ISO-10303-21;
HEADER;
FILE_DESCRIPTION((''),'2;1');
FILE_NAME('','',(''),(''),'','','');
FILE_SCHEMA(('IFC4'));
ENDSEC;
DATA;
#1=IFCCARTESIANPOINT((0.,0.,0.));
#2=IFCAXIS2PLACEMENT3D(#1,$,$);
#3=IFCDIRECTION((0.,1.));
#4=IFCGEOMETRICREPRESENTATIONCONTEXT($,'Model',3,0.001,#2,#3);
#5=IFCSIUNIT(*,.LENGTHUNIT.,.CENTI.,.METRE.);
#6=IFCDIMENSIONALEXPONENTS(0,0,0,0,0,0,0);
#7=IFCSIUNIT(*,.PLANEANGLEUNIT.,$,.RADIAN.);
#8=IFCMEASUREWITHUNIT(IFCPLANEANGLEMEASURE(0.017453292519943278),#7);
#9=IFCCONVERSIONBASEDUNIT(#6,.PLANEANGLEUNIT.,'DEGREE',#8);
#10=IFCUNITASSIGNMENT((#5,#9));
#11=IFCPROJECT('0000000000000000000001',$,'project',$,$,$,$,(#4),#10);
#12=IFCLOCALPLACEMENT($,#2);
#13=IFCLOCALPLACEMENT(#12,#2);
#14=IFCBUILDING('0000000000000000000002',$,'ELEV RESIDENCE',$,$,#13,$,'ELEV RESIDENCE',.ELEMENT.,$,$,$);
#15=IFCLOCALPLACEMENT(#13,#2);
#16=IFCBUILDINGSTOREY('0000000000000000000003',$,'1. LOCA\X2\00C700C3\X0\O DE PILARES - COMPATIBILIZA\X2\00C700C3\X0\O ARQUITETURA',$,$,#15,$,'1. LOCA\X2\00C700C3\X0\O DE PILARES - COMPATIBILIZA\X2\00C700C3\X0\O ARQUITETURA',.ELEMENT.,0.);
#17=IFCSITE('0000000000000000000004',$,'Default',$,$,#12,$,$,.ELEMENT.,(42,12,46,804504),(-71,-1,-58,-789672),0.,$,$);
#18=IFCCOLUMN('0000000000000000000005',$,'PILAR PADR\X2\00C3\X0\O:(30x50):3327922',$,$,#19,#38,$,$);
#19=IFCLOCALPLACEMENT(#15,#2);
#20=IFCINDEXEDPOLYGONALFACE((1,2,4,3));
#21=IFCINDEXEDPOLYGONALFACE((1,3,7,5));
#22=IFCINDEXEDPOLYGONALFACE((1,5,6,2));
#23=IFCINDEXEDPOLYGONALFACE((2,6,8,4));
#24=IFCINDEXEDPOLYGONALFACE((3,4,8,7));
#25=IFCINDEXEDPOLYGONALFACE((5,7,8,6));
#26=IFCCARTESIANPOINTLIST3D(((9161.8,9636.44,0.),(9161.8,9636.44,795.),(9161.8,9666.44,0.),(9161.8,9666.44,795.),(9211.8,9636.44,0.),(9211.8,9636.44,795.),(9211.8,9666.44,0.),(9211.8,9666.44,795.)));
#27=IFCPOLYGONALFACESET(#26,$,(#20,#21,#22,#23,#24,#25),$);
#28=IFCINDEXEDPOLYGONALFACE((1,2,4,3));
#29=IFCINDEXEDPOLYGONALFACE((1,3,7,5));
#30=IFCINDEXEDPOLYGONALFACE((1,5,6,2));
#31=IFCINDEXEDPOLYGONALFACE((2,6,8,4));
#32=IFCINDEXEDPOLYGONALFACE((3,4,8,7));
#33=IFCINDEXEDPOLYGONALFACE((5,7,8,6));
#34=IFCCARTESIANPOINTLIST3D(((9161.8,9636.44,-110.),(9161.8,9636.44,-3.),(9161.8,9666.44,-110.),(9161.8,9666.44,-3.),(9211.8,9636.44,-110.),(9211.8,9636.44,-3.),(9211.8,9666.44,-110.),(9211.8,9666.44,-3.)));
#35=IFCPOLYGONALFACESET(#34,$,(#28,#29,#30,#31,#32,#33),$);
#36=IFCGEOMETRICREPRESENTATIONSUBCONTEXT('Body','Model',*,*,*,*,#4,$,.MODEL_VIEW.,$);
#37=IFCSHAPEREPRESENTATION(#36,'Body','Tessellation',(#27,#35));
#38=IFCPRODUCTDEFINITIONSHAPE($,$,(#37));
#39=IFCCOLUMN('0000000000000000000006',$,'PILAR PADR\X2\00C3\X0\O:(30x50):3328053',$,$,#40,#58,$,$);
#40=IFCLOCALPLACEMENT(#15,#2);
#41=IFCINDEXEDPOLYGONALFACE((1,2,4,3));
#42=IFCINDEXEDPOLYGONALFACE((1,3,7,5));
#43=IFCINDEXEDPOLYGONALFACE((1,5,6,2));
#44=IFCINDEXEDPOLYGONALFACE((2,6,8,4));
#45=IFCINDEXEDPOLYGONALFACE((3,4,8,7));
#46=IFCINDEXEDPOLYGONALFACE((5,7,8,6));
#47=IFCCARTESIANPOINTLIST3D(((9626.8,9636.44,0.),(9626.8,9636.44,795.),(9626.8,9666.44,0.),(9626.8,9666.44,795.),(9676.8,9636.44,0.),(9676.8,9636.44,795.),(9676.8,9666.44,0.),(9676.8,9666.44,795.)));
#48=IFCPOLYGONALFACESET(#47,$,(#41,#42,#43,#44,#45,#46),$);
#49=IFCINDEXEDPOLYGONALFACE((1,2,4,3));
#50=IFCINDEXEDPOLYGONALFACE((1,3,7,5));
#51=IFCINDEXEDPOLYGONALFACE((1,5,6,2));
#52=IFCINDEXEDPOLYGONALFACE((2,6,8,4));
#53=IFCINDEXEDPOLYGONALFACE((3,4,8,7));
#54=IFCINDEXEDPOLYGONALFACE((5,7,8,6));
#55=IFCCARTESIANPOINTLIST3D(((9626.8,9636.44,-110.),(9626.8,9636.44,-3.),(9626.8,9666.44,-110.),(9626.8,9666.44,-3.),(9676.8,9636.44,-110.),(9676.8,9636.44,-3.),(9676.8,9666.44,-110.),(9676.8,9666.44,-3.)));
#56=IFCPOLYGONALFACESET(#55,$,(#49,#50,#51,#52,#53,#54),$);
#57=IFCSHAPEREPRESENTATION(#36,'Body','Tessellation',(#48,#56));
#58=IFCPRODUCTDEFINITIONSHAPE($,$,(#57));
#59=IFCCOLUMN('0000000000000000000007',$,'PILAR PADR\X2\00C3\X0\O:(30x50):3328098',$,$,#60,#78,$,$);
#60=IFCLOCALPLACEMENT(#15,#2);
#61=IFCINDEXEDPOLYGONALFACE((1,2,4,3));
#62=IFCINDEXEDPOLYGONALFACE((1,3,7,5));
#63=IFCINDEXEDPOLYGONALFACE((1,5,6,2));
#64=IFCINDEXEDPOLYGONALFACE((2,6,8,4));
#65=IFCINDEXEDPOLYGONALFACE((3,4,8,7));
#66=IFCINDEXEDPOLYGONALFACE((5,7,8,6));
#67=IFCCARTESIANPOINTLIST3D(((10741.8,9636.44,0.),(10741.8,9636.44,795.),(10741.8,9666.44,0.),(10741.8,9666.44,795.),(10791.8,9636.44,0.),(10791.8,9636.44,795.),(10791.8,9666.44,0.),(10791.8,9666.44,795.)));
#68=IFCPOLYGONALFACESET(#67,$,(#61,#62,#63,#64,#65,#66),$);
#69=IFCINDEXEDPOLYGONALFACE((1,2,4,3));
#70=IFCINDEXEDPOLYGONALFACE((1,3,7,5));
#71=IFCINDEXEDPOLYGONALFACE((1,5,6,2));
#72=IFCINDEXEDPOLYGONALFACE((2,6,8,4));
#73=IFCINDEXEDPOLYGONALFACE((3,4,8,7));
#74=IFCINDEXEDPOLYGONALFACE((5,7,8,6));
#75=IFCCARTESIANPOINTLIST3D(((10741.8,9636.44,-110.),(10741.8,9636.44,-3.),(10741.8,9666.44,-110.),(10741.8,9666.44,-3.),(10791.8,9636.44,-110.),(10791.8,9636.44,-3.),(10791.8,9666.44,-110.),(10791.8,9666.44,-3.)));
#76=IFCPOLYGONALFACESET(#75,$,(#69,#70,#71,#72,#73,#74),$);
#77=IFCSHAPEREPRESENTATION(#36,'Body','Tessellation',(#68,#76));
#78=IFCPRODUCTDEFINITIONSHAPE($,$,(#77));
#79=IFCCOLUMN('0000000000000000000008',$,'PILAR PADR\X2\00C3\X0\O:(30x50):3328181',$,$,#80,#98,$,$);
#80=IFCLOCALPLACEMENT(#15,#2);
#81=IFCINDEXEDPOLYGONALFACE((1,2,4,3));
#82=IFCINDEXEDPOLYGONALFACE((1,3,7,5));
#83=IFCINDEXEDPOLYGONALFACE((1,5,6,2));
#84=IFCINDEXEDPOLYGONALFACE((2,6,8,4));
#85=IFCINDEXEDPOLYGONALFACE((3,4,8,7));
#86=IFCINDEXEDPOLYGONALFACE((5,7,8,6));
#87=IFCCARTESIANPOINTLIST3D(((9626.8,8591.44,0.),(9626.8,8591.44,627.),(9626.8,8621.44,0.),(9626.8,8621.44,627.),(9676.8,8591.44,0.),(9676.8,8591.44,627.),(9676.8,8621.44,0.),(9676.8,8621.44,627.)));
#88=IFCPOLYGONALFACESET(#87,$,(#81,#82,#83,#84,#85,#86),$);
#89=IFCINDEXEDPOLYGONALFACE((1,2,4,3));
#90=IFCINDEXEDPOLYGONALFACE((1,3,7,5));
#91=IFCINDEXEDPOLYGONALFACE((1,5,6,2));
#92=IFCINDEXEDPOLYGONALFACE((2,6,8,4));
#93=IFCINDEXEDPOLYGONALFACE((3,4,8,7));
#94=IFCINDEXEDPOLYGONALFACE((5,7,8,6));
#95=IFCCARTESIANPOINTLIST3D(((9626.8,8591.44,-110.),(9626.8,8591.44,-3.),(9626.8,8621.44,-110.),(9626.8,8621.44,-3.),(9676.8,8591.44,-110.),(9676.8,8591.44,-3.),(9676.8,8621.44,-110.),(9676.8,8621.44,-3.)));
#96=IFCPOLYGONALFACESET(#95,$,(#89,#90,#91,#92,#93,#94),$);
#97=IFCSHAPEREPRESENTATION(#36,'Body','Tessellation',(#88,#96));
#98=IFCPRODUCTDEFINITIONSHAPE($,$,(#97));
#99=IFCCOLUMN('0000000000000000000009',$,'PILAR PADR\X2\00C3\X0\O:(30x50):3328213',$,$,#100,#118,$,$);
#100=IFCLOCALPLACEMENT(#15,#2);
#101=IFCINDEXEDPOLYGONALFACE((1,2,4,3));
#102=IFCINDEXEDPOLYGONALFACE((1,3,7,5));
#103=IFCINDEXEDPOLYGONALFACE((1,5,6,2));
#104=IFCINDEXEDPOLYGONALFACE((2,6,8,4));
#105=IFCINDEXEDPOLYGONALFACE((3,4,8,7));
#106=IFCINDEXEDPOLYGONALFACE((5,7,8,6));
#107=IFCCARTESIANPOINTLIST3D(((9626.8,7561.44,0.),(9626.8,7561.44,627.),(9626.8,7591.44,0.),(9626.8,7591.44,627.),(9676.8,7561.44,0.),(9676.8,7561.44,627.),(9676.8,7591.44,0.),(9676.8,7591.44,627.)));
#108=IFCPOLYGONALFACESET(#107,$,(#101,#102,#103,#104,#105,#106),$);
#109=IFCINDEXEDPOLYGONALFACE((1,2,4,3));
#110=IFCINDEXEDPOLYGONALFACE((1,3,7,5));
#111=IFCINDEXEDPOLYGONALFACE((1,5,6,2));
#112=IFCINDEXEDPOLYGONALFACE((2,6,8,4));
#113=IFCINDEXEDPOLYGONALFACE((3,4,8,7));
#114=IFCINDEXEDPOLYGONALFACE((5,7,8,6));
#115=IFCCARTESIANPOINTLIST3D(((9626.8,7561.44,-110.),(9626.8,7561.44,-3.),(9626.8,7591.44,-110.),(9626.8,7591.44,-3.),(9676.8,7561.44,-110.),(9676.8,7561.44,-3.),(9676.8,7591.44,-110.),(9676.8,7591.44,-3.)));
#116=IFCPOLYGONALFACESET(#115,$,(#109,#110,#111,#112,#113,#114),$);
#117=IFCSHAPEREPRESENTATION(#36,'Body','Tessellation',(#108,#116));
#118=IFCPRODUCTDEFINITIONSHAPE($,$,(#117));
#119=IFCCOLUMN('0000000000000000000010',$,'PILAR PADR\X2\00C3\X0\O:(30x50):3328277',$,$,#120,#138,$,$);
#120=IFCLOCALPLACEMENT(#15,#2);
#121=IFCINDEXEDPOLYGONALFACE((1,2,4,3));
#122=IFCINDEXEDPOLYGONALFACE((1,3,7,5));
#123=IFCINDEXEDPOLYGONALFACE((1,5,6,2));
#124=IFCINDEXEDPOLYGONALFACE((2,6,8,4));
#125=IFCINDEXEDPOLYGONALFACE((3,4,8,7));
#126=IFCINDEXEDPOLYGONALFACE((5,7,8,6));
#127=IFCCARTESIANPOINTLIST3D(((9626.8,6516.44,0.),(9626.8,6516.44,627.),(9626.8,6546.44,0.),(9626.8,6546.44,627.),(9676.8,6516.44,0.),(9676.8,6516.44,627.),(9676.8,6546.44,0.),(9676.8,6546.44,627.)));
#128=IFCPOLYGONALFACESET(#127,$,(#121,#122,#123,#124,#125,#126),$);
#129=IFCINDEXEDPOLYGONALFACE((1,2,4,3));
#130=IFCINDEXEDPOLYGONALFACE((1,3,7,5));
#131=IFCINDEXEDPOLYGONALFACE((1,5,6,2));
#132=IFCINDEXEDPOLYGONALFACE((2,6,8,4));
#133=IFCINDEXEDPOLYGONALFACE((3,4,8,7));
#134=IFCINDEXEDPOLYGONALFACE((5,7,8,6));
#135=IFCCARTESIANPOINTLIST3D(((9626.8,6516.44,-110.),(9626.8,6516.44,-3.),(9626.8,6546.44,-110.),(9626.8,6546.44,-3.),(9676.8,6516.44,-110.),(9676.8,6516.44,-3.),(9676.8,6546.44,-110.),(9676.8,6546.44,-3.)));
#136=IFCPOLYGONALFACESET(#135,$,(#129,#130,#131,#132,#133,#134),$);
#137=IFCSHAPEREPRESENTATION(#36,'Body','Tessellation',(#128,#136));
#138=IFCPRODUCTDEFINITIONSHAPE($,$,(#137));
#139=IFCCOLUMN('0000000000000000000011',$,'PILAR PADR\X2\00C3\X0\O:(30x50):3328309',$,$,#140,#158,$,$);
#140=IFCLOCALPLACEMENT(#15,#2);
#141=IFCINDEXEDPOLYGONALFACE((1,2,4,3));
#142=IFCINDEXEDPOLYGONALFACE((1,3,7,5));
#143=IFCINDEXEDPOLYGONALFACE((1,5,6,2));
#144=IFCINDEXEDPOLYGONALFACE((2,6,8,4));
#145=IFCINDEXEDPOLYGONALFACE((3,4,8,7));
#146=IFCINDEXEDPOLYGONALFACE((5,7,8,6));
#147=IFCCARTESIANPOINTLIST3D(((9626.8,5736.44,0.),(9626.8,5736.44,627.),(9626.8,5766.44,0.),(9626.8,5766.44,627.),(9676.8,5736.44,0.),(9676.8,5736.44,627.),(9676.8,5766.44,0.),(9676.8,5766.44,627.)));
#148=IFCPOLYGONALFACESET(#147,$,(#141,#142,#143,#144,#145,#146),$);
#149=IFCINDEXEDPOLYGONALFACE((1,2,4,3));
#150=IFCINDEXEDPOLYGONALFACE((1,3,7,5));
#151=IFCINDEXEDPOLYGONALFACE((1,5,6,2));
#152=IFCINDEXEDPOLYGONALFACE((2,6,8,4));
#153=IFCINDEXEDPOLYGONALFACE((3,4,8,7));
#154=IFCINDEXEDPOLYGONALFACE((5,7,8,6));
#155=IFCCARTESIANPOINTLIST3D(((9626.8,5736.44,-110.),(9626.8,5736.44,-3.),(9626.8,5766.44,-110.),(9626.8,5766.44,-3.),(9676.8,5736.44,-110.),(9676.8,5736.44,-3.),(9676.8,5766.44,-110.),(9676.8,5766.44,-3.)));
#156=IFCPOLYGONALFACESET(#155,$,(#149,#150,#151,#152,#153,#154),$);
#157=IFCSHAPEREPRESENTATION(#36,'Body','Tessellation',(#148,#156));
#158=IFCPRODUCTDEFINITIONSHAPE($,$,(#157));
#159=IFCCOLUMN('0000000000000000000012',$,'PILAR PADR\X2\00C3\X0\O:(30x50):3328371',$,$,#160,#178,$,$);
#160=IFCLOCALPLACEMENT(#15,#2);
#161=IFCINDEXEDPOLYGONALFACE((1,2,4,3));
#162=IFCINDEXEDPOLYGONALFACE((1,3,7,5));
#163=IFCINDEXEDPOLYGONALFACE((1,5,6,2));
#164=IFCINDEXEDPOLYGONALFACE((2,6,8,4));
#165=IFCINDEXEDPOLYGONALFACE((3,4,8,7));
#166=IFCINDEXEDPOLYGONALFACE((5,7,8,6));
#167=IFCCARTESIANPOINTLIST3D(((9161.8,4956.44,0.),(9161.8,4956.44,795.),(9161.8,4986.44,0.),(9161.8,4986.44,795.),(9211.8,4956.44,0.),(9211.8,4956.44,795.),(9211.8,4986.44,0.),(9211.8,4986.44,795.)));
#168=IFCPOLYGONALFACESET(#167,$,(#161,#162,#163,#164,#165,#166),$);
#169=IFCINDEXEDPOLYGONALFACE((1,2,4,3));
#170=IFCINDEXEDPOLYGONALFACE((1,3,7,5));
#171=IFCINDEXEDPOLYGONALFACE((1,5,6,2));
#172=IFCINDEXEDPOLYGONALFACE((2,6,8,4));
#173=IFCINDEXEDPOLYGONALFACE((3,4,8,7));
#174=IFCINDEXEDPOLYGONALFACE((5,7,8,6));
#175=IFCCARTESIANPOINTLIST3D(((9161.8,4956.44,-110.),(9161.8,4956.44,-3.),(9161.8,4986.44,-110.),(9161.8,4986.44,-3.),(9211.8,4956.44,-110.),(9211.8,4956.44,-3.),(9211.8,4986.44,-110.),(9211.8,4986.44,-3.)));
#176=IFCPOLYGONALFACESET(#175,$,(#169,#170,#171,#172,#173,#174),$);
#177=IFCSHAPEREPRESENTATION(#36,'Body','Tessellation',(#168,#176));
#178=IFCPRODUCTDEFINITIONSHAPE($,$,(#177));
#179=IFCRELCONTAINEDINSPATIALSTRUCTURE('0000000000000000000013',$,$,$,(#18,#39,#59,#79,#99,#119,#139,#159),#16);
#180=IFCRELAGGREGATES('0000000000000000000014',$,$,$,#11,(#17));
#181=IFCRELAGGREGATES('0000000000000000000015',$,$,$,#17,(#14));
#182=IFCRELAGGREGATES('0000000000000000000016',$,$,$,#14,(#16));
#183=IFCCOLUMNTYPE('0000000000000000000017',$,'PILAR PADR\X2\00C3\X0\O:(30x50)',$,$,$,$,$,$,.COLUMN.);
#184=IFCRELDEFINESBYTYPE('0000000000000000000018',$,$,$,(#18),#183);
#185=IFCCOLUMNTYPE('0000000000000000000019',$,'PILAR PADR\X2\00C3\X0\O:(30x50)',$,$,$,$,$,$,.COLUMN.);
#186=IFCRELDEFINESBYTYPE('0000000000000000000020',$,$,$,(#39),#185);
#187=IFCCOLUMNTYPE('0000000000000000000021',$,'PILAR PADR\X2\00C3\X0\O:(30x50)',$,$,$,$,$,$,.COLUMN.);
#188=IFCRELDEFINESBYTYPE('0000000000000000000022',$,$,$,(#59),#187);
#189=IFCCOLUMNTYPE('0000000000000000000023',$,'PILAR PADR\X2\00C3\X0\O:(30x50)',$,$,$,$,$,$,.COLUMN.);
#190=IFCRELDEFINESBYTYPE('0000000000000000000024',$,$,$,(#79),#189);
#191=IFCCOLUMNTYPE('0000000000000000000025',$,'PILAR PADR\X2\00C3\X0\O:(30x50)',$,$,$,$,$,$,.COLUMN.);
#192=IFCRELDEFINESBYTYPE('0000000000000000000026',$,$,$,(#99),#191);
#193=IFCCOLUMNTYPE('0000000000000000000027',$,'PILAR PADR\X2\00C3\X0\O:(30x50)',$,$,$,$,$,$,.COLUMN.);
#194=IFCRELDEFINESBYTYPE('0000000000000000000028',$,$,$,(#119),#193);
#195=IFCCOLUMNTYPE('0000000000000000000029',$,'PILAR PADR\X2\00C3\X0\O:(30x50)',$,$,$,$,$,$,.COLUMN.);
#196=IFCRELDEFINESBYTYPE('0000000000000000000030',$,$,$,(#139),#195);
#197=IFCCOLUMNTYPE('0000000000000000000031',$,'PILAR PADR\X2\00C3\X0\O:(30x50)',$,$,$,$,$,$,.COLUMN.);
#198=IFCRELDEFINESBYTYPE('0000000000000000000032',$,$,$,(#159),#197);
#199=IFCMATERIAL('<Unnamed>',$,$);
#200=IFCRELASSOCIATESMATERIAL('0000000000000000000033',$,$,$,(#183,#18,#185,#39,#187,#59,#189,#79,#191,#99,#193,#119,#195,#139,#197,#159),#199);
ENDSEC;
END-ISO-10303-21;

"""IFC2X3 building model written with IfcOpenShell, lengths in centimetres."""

from ifc_helpers import new_model, entity, si_unit, converted_unit, direction, frame, frame_2d, origin, origin_2d_with_axis, place, context, subcontext, project, spatial, rectangle, extrude, source, transform, mapped, material, type_object, type_shapes, element, save


model = new_model("IFC2X3")

# Units and contexts
model_context = context("Model", 3, precision=0.001, world=origin(), true_north=direction((0.0, 1.0)))
body_context = subcontext(model_context, "Body", "Model", "MODEL_VIEW")
ifc_project = project(units=[si_unit("LENGTHUNIT", "METRE", prefix="CENTI"), converted_unit("PLANEANGLEUNIT", "DEGREE", entity("IfcPlaneAngleMeasure", 0.017453292519943278), si_unit("PLANEANGLEUNIT", "RADIAN"), dimensions=[0, 0, 0, 0, 0, 0, 0])], contexts=[model_context])

# Site, building, storey
site_placement = place(None, origin())
site = spatial("IfcSite", under=ifc_project, at=site_placement, Name="Default", CompositionType="ELEMENT", RefLatitude=(42, 12, 46, 804504), RefLongitude=(-71, -1, -58, -789672), RefElevation=0.0)
building_placement = place(site_placement, origin())
building = spatial("IfcBuilding", under=site, at=building_placement, Name="ELEV RESIDENCE", LongName="ELEV RESIDENCE", CompositionType="ELEMENT")
storey_placement = place(building_placement, origin())
storey = spatial("IfcBuildingStorey", under=building, at=storey_placement, Name="1. LOCAÇÃO DE PILARES - COMPATIBILIZAÇÃO ARQUITETURA", LongName="1. LOCAÇÃO DE PILARES - COMPATIBILIZAÇÃO ARQUITETURA", CompositionType="ELEMENT", Elevation=0.0)

# Columns
ifc_material_1 = material(Name="<Unnamed>")
column_type_1 = type_object("IfcColumnType", Name="PILAR PADRÃO:(30x50)", PredefinedType="COLUMN", material=ifc_material_1)
shared_shape_1 = source(origin(), body_context, "Body", "SweptSolid", [
    extrude(rectangle(XDim=795.0, YDim=30.0, at=origin_2d_with_axis()), frame((9161.8, 9651.44, 397.5), z_axis=(1.0, 0.0, 0.0), x_axis=(0.0, 0.0, -1.0)), (0.0, 0.0, 1.0), 50.0),
    extrude(rectangle(XDim=107.0, YDim=30.0, at=frame_2d((0.0, 0.0), x_axis=(1.0, 0.0))), frame((9161.8, 9651.44, -56.5), z_axis=(1.0, 0.0, 0.0), x_axis=(0.0, 0.0, 1.0)), (0.0, 0.0, 1.0), 50.0),
])
type_shapes(column_type_1, [shared_shape_1])
column_1_placement = place(storey_placement, origin())
element("IfcColumn", 1, at=column_1_placement, inside=storey, type_object=column_type_1, material=ifc_material_1, Name="PILAR PADRÃO:(30x50):3327922", context=body_context, shape_type="MappedRepresentation", body=[
    mapped(shared_shape_1, transform((0.0, 0.0, 0.0), scale=1.0)),
])
column_type_2 = type_object("IfcColumnType", Name="PILAR PADRÃO:(30x50)", PredefinedType="COLUMN", material=ifc_material_1)
shared_shape_2 = source(origin(), body_context, "Body", "SweptSolid", [
    extrude(rectangle(XDim=795.0, YDim=30.0, at=frame_2d((-86.75, 0.0), x_axis=(1.0, 0.0))), frame((9626.8, 9651.44, 310.75), z_axis=(1.0, 0.0, 0.0), x_axis=(0.0, 0.0, -1.0)), (0.0, 0.0, 1.0), 50.0),
    extrude(rectangle(XDim=107.0, YDim=30.0, at=frame_2d((0.0, 0.0), x_axis=(1.0, 0.0))), frame((9626.8, 9651.44, -56.5), z_axis=(1.0, 0.0, 0.0), x_axis=(0.0, 0.0, 1.0)), (0.0, 0.0, 1.0), 50.0),
])
type_shapes(column_type_2, [shared_shape_2])
column_2_placement = place(storey_placement, origin())
element("IfcColumn", 2, at=column_2_placement, inside=storey, type_object=column_type_2, material=ifc_material_1, Name="PILAR PADRÃO:(30x50):3328053", context=body_context, shape_type="MappedRepresentation", body=[
    mapped(shared_shape_2, transform((0.0, 0.0, 0.0), scale=1.0)),
])
column_type_3 = type_object("IfcColumnType", Name="PILAR PADRÃO:(30x50)", PredefinedType="COLUMN", material=ifc_material_1)
shared_shape_3 = source(origin(), body_context, "Body", "SweptSolid", [
    extrude(rectangle(XDim=795.0, YDim=30.0, at=frame_2d((-86.75, 0.0), x_axis=(1.0, 0.0))), frame((10741.8, 9651.44, 310.75), z_axis=(1.0, 0.0, 0.0), x_axis=(0.0, 0.0, -1.0)), (0.0, 0.0, 1.0), 50.0),
    extrude(rectangle(XDim=107.0, YDim=30.0, at=frame_2d((0.0, 0.0), x_axis=(1.0, 0.0))), frame((10741.8, 9651.44, -56.5), z_axis=(1.0, 0.0, 0.0), x_axis=(0.0, 0.0, 1.0)), (0.0, 0.0, 1.0), 50.0),
])
type_shapes(column_type_3, [shared_shape_3])
column_3_placement = place(storey_placement, origin())
element("IfcColumn", 3, at=column_3_placement, inside=storey, type_object=column_type_3, material=ifc_material_1, Name="PILAR PADRÃO:(30x50):3328098", context=body_context, shape_type="MappedRepresentation", body=[
    mapped(shared_shape_3, transform((0.0, 0.0, 0.0), scale=1.0)),
])
column_type_4 = type_object("IfcColumnType", Name="PILAR PADRÃO:(30x50)", PredefinedType="COLUMN", material=ifc_material_1)
shared_shape_4 = source(origin(), body_context, "Body", "SweptSolid", [
    extrude(rectangle(XDim=627.0, YDim=30.0, at=origin_2d_with_axis()), frame((9626.8, 8606.44, 313.5), z_axis=(1.0, 0.0, 0.0), x_axis=(0.0, 0.0, -1.0)), (0.0, 0.0, 1.0), 50.0),
    extrude(rectangle(XDim=107.0, YDim=30.0, at=frame_2d((0.0, 0.0), x_axis=(1.0, 0.0))), frame((9626.8, 8606.44, -56.5), z_axis=(1.0, 0.0, 0.0), x_axis=(0.0, 0.0, 1.0)), (0.0, 0.0, 1.0), 50.0),
])
type_shapes(column_type_4, [shared_shape_4])
column_4_placement = place(storey_placement, origin())
element("IfcColumn", 4, at=column_4_placement, inside=storey, type_object=column_type_4, material=ifc_material_1, Name="PILAR PADRÃO:(30x50):3328181", context=body_context, shape_type="MappedRepresentation", body=[
    mapped(shared_shape_4, transform((0.0, 0.0, 0.0), scale=1.0)),
])
column_type_5 = type_object("IfcColumnType", Name="PILAR PADRÃO:(30x50)", PredefinedType="COLUMN", material=ifc_material_1)
shared_shape_5 = source(origin(), body_context, "Body", "SweptSolid", [
    extrude(rectangle(XDim=627.0, YDim=30.0, at=origin_2d_with_axis()), frame((9626.8, 7576.44, 313.5), z_axis=(1.0, 0.0, 0.0), x_axis=(0.0, 0.0, -1.0)), (0.0, 0.0, 1.0), 50.0),
    extrude(rectangle(XDim=107.0, YDim=30.0, at=frame_2d((0.0, 0.0), x_axis=(1.0, 0.0))), frame((9626.8, 7576.44, -56.5), z_axis=(1.0, 0.0, 0.0), x_axis=(0.0, 0.0, 1.0)), (0.0, 0.0, 1.0), 50.0),
])
type_shapes(column_type_5, [shared_shape_5])
column_5_placement = place(storey_placement, origin())
element("IfcColumn", 5, at=column_5_placement, inside=storey, type_object=column_type_5, material=ifc_material_1, Name="PILAR PADRÃO:(30x50):3328213", context=body_context, shape_type="MappedRepresentation", body=[
    mapped(shared_shape_5, transform((0.0, 0.0, 0.0), scale=1.0)),
])
column_type_6 = type_object("IfcColumnType", Name="PILAR PADRÃO:(30x50)", PredefinedType="COLUMN", material=ifc_material_1)
shared_shape_6 = source(origin(), body_context, "Body", "SweptSolid", [
    extrude(rectangle(XDim=627.0, YDim=30.0, at=origin_2d_with_axis()), frame((9626.8, 6531.44, 313.5), z_axis=(1.0, 0.0, 0.0), x_axis=(0.0, 0.0, -1.0)), (0.0, 0.0, 1.0), 50.0),
    extrude(rectangle(XDim=107.0, YDim=30.0, at=frame_2d((0.0, 0.0), x_axis=(1.0, 0.0))), frame((9626.8, 6531.44, -56.5), z_axis=(1.0, 0.0, 0.0), x_axis=(0.0, 0.0, 1.0)), (0.0, 0.0, 1.0), 50.0),
])
type_shapes(column_type_6, [shared_shape_6])
column_6_placement = place(storey_placement, origin())
element("IfcColumn", 6, at=column_6_placement, inside=storey, type_object=column_type_6, material=ifc_material_1, Name="PILAR PADRÃO:(30x50):3328277", context=body_context, shape_type="MappedRepresentation", body=[
    mapped(shared_shape_6, transform((0.0, 0.0, 0.0), scale=1.0)),
])
column_type_7 = type_object("IfcColumnType", Name="PILAR PADRÃO:(30x50)", PredefinedType="COLUMN", material=ifc_material_1)
shared_shape_7 = source(origin(), body_context, "Body", "SweptSolid", [
    extrude(rectangle(XDim=627.0, YDim=30.0, at=origin_2d_with_axis()), frame((9626.8, 5751.44, 313.5), z_axis=(1.0, 0.0, 0.0), x_axis=(0.0, 0.0, -1.0)), (0.0, 0.0, 1.0), 50.0),
    extrude(rectangle(XDim=107.0, YDim=30.0, at=frame_2d((0.0, 0.0), x_axis=(1.0, 0.0))), frame((9626.8, 5751.44, -56.5), z_axis=(1.0, 0.0, 0.0), x_axis=(0.0, 0.0, 1.0)), (0.0, 0.0, 1.0), 50.0),
])
type_shapes(column_type_7, [shared_shape_7])
column_7_placement = place(storey_placement, origin())
element("IfcColumn", 7, at=column_7_placement, inside=storey, type_object=column_type_7, material=ifc_material_1, Name="PILAR PADRÃO:(30x50):3328309", context=body_context, shape_type="MappedRepresentation", body=[
    mapped(shared_shape_7, transform((0.0, 0.0, 0.0), scale=1.0)),
])
column_type_8 = type_object("IfcColumnType", Name="PILAR PADRÃO:(30x50)", PredefinedType="COLUMN", material=ifc_material_1)
shared_shape_8 = source(origin(), body_context, "Body", "SweptSolid", [
    extrude(rectangle(XDim=795.0, YDim=30.0, at=origin_2d_with_axis()), frame((9161.8, 4971.44, 397.5), z_axis=(1.0, 0.0, 0.0), x_axis=(0.0, 0.0, -1.0)), (0.0, 0.0, 1.0), 50.0),
    extrude(rectangle(XDim=107.0, YDim=30.0, at=frame_2d((0.0, 0.0), x_axis=(1.0, 0.0))), frame((9161.8, 4971.44, -56.5), z_axis=(1.0, 0.0, 0.0), x_axis=(0.0, 0.0, 1.0)), (0.0, 0.0, 1.0), 50.0),
])
type_shapes(column_type_8, [shared_shape_8])
column_8_placement = place(storey_placement, origin())
element("IfcColumn", 8, at=column_8_placement, inside=storey, type_object=column_type_8, material=ifc_material_1, Name="PILAR PADRÃO:(30x50):3328371", context=body_context, shape_type="MappedRepresentation", body=[
    mapped(shared_shape_8, transform((0.0, 0.0, 0.0), scale=1.0)),
])

save(model, "model.ifc")
